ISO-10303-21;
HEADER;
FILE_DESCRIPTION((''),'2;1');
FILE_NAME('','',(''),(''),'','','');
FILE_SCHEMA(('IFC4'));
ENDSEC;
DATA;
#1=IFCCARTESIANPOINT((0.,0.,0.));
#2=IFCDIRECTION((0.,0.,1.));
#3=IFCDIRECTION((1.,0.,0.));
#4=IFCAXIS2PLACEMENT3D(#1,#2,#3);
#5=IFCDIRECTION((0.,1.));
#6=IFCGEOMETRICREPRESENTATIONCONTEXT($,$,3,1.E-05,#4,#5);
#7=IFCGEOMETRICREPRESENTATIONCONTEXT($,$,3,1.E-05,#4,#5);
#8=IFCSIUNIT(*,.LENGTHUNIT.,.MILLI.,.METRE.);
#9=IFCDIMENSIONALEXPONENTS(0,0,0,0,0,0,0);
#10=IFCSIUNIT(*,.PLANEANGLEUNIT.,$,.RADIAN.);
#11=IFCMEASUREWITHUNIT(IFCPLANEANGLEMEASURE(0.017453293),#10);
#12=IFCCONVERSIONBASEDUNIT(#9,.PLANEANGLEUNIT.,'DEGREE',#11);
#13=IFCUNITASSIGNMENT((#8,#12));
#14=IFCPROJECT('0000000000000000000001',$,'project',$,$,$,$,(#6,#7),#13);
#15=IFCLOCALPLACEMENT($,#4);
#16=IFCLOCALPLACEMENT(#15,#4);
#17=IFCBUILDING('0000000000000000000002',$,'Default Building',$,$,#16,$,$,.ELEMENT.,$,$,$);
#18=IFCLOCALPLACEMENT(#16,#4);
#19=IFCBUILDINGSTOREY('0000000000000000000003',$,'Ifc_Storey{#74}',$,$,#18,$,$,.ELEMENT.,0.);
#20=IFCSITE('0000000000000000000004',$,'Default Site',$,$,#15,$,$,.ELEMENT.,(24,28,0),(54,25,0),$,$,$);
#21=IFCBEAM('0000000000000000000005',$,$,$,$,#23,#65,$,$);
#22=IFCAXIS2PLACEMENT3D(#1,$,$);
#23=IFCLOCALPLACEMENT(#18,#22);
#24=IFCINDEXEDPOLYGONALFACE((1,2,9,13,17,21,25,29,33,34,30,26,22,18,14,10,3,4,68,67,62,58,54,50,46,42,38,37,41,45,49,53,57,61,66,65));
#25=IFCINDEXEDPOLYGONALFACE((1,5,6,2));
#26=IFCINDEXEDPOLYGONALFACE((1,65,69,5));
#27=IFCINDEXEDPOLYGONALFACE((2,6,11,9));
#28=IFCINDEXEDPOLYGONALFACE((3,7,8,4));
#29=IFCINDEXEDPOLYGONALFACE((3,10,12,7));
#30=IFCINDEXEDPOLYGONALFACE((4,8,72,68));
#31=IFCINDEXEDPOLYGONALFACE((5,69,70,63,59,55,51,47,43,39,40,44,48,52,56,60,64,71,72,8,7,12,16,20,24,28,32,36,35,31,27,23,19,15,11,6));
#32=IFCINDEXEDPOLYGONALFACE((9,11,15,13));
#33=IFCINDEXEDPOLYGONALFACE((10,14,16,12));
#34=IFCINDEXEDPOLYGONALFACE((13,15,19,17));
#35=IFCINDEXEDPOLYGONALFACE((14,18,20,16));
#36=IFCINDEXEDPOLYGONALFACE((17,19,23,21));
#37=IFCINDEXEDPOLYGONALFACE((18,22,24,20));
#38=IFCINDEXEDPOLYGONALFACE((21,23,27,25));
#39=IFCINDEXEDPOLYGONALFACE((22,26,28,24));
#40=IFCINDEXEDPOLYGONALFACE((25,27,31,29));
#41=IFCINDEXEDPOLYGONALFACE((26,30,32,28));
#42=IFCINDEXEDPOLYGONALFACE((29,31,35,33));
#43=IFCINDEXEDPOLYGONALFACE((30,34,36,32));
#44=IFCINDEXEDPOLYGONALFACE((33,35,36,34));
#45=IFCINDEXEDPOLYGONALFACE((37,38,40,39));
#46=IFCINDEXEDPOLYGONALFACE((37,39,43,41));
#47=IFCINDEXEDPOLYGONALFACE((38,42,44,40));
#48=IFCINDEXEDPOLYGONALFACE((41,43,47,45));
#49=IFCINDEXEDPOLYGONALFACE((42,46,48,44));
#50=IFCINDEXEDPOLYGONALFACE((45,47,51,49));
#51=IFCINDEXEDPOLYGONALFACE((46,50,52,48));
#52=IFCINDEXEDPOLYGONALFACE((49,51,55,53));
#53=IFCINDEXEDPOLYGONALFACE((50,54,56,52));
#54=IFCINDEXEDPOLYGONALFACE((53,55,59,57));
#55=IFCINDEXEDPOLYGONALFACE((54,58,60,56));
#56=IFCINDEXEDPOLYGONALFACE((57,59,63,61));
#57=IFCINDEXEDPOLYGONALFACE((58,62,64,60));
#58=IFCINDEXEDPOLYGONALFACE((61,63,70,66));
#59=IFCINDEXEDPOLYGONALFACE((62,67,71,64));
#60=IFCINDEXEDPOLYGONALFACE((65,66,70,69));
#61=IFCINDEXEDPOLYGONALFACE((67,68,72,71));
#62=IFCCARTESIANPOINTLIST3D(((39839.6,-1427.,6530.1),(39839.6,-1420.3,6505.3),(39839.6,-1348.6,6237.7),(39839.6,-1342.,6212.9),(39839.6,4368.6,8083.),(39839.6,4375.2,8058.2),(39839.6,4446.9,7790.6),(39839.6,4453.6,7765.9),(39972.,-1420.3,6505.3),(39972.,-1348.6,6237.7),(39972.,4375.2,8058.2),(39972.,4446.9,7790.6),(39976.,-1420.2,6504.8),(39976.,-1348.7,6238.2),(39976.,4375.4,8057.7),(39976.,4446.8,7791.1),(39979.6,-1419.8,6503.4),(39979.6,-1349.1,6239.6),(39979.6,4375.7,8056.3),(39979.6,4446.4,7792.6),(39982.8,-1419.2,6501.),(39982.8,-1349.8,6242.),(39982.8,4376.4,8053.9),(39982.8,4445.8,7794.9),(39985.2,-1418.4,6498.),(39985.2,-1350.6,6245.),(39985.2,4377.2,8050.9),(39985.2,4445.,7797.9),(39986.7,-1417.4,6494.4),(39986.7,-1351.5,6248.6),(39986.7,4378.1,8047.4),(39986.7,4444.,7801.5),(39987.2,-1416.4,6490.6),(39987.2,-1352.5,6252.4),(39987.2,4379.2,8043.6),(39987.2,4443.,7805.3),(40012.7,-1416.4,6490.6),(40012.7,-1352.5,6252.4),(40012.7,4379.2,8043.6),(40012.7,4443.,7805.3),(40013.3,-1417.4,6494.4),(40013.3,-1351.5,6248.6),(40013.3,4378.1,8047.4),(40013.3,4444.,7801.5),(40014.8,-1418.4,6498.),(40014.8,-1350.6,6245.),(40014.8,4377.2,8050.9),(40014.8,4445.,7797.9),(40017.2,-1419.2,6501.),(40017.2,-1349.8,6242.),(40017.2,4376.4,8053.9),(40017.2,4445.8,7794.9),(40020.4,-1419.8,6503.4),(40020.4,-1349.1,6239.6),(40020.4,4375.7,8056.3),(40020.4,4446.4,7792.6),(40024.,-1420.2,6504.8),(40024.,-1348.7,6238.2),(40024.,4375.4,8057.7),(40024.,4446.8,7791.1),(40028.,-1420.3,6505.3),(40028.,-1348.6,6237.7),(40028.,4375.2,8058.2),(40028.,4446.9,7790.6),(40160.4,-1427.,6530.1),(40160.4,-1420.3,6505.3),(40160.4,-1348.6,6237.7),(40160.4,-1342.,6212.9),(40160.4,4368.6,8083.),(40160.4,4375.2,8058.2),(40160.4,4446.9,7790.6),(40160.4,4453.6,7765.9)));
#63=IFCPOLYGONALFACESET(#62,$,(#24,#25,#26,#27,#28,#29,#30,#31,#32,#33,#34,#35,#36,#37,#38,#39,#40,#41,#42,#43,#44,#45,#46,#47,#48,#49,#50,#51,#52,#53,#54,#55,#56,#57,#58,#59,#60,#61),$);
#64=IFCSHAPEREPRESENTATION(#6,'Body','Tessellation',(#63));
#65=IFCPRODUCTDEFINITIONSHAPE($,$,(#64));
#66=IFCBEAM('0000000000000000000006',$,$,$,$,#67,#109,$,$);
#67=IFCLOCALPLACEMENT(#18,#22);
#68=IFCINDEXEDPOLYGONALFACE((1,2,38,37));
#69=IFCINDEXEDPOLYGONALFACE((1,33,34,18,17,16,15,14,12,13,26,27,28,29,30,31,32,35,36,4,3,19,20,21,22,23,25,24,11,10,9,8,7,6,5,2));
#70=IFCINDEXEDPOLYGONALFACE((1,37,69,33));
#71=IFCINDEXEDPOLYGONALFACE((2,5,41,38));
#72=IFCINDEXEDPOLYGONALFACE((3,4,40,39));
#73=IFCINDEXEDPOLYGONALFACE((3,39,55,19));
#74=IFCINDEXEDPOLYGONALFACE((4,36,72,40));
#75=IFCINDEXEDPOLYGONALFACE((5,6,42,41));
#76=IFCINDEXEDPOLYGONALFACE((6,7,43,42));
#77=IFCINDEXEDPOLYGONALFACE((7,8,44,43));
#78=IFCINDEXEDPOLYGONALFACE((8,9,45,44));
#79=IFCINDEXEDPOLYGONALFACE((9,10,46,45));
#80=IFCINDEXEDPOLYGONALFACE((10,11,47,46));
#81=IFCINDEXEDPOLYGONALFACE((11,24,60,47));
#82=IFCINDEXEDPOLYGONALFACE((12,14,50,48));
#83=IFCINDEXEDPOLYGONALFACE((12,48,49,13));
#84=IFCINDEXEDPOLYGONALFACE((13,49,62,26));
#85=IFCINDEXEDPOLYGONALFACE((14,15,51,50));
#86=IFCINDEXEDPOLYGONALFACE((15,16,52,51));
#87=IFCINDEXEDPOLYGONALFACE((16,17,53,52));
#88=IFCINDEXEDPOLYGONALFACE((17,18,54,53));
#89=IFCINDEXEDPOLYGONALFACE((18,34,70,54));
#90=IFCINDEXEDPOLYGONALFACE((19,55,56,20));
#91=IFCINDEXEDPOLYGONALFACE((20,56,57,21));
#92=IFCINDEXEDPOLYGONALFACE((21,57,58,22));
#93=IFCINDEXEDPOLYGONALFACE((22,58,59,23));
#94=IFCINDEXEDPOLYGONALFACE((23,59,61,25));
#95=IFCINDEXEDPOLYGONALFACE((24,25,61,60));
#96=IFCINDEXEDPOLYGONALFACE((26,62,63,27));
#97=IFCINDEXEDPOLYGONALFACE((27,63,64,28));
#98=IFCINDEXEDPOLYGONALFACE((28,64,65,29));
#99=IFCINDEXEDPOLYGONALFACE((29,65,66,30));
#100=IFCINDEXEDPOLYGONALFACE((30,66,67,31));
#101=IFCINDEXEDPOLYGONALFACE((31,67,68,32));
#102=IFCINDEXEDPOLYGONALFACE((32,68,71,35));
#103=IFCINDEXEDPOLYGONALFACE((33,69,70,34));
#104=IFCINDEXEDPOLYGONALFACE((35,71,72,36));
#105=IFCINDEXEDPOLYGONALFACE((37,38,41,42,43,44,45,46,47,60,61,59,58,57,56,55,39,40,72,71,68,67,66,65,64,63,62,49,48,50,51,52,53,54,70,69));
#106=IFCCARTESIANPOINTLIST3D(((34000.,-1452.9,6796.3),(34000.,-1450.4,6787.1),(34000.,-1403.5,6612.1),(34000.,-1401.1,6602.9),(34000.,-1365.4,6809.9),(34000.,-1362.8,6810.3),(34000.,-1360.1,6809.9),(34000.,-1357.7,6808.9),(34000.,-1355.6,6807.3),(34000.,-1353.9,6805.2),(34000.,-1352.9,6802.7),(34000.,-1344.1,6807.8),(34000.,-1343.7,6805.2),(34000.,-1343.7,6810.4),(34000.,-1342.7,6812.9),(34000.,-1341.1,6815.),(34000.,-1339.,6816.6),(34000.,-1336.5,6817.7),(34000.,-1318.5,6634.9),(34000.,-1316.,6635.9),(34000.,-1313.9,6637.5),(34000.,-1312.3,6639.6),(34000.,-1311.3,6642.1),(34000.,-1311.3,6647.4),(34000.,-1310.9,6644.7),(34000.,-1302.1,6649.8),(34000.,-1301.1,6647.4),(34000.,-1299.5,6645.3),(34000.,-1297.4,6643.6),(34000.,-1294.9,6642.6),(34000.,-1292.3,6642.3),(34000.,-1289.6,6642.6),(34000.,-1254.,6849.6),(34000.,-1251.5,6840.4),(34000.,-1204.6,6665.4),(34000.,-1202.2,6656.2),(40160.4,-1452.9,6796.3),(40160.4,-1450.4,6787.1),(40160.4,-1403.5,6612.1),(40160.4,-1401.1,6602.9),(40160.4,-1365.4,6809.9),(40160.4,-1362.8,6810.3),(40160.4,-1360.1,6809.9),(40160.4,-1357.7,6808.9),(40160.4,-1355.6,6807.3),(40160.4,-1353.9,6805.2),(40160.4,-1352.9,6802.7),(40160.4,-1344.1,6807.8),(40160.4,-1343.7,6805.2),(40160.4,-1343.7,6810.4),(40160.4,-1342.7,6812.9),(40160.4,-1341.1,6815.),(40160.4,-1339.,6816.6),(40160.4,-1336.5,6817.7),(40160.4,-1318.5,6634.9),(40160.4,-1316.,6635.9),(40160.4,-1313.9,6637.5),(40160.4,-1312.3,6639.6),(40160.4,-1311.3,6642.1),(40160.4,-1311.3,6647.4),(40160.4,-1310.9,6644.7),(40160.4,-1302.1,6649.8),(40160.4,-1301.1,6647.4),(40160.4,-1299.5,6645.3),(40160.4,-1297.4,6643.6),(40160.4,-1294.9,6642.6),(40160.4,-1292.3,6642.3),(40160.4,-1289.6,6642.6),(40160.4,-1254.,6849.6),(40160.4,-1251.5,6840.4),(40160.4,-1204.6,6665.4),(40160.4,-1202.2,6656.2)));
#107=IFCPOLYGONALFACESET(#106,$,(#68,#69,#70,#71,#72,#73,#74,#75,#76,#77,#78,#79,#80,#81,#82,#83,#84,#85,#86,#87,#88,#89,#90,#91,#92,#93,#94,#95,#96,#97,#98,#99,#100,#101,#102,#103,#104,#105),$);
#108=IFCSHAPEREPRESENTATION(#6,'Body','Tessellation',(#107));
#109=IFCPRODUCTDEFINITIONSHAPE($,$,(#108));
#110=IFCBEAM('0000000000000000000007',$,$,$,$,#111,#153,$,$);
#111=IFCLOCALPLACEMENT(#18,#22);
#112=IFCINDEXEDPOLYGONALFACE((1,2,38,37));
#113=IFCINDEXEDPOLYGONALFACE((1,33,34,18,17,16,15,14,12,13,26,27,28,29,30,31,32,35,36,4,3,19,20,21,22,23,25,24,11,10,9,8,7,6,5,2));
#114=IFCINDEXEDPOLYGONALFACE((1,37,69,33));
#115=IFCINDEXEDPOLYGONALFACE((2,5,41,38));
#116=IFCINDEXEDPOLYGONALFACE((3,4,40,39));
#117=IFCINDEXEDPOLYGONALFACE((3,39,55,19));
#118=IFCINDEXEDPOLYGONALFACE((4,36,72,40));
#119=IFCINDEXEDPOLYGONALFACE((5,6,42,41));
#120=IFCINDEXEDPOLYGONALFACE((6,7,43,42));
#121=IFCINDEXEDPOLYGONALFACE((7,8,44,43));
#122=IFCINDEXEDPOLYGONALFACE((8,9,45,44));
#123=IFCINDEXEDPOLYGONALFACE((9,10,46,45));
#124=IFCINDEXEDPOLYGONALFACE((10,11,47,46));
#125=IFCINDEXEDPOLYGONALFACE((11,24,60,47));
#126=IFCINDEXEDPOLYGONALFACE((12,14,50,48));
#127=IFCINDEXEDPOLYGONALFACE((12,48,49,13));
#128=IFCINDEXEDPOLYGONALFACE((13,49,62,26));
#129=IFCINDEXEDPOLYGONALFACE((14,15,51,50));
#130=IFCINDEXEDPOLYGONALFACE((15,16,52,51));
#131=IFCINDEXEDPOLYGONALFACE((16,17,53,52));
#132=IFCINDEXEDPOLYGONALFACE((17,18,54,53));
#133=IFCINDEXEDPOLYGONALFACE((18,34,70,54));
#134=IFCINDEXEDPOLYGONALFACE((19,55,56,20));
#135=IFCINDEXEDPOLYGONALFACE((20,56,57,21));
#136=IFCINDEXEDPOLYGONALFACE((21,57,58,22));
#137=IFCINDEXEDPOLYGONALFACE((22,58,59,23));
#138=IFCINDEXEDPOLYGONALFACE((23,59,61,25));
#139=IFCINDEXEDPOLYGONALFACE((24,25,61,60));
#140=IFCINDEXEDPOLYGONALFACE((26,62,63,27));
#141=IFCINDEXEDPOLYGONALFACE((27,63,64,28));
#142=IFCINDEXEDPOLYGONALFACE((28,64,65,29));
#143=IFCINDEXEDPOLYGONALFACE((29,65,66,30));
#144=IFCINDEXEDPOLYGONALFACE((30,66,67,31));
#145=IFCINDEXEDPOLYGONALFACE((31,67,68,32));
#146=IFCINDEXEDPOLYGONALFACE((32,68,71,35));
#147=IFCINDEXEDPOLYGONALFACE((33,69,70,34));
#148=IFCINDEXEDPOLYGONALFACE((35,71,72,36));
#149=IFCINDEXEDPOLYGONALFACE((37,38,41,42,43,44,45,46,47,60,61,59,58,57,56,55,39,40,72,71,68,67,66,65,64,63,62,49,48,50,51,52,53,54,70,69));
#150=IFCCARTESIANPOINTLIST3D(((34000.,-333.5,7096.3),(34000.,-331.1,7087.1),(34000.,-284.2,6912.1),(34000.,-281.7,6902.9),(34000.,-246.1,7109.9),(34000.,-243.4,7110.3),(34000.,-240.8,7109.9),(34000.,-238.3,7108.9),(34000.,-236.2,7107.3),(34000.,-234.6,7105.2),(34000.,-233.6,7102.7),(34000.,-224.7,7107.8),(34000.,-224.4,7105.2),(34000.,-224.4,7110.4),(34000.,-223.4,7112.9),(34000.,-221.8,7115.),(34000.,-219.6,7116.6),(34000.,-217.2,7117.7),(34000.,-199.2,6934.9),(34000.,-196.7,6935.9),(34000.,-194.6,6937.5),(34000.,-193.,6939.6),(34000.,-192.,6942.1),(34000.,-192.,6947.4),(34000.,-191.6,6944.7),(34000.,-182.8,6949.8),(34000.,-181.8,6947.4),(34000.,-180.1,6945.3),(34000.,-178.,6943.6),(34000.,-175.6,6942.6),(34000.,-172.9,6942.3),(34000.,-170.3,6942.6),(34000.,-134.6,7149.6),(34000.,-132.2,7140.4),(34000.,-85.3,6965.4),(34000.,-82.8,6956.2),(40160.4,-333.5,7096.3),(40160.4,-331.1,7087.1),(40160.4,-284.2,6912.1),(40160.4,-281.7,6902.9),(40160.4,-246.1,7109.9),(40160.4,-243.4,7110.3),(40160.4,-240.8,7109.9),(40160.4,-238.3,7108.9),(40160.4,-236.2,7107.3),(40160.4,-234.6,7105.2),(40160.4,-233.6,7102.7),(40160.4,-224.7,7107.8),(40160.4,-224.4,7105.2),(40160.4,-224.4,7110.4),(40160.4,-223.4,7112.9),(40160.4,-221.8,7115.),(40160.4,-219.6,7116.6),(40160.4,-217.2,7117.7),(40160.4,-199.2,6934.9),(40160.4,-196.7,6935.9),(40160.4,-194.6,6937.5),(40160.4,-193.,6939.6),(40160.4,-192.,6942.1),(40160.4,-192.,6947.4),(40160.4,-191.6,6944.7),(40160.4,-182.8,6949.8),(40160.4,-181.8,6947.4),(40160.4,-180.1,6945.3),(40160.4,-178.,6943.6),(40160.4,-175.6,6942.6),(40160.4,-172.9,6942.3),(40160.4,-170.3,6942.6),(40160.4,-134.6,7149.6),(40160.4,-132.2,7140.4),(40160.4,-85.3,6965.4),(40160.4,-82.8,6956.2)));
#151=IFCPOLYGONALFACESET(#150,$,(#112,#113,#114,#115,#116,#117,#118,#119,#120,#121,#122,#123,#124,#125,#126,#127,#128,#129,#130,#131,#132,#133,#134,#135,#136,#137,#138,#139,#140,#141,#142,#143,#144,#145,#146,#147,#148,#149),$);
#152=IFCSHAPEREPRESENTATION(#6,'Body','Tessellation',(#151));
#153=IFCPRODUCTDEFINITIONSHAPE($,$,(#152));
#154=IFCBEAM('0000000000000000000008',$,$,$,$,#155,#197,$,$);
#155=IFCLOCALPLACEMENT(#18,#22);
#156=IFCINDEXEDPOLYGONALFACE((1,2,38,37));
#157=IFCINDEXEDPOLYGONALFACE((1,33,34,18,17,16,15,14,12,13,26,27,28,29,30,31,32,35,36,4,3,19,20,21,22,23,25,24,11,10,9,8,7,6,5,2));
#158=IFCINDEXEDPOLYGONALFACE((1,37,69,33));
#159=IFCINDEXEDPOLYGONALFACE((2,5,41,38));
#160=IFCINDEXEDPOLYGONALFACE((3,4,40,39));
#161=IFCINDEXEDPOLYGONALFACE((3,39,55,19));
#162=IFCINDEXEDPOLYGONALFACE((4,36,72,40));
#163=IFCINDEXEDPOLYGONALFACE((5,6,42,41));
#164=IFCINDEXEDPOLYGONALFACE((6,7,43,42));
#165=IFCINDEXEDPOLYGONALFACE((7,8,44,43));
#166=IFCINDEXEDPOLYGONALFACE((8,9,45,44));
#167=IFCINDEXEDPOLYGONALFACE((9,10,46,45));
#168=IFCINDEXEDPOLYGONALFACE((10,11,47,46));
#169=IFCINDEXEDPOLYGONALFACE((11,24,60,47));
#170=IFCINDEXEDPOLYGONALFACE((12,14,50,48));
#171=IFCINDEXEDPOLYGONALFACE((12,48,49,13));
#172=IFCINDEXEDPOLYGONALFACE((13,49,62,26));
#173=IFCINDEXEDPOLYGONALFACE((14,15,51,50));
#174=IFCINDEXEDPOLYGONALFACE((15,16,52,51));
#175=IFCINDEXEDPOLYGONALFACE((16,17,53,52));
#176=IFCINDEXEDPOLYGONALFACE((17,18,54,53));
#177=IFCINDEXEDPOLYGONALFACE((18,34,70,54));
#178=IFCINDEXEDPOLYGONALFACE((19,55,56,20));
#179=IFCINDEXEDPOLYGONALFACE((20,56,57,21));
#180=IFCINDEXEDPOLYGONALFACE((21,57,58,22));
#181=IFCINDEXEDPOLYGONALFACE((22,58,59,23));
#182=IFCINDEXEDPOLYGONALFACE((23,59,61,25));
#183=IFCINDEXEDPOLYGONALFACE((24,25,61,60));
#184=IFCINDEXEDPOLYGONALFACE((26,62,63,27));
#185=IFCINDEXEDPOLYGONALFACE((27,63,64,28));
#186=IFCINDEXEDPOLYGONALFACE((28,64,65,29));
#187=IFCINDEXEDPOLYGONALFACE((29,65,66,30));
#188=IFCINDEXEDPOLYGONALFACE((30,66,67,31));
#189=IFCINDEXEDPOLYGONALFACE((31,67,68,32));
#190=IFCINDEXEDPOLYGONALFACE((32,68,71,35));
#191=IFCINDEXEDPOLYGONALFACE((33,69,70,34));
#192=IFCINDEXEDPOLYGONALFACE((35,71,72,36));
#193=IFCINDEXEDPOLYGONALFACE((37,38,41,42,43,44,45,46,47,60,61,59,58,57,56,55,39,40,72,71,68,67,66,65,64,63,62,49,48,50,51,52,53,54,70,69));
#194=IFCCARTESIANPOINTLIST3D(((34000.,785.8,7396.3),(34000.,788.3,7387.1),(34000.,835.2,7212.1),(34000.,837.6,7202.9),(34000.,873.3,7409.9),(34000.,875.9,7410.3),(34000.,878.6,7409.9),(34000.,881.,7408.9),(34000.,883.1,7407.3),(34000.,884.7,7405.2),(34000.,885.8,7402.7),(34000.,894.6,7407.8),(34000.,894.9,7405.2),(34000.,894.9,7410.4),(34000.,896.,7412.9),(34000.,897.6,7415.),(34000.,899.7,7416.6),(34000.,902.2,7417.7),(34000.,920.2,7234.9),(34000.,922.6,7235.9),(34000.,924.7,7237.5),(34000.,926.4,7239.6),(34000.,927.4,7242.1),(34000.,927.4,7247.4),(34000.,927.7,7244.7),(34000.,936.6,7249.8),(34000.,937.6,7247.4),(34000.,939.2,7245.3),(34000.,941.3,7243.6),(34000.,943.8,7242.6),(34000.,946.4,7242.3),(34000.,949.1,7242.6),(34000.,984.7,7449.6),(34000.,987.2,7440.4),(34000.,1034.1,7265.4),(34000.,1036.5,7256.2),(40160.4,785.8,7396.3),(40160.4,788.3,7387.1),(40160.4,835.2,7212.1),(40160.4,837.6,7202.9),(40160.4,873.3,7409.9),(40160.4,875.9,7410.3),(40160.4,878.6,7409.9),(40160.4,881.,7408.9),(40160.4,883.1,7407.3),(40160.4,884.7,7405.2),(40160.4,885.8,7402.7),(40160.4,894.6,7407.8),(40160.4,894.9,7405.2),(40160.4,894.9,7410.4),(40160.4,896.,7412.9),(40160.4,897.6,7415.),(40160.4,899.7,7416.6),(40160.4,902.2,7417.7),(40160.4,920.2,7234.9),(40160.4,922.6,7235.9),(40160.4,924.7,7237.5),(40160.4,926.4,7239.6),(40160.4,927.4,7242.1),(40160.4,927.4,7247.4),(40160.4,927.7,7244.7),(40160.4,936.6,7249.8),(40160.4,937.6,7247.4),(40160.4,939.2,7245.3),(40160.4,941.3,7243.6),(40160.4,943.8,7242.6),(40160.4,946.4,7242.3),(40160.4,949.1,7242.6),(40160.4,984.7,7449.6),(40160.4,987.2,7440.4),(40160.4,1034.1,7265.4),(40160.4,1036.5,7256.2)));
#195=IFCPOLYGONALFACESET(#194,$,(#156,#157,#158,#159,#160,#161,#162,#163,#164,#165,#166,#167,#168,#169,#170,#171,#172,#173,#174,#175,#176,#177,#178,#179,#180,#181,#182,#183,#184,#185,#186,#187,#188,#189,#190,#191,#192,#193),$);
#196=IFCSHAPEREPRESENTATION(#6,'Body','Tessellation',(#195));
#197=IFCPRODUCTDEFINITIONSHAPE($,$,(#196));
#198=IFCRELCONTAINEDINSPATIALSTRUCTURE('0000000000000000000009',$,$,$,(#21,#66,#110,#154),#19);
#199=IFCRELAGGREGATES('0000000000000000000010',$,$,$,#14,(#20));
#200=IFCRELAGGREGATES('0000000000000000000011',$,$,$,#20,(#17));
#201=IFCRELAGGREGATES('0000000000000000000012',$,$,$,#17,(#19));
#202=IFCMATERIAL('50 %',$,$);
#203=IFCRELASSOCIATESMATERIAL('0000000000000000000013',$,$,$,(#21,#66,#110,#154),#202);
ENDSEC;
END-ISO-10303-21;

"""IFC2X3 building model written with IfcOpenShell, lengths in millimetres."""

from ifc_helpers import new_model, entity, si_unit, converted_unit, direction, frame, origin_with_axes, origin_2d_with_axis, place, context, project, spatial, i_section, extrude, material, element, save


model = new_model("IFC2X3")

# Units and contexts
context_of_model_1 = context(None, 3, precision=1e-05, world=origin_with_axes(), true_north=direction((0.0, 1.0)))
context_of_model_2 = context(None, 3, precision=1e-05, world=origin_with_axes(), true_north=direction((0.0, 1.0)))
ifc_project = project(units=[si_unit("LENGTHUNIT", "METRE", prefix="MILLI"), converted_unit("PLANEANGLEUNIT", "DEGREE", entity("IfcPlaneAngleMeasure", 0.017453293), si_unit("PLANEANGLEUNIT", "RADIAN"), dimensions=[0, 0, 0, 0, 0, 0, 0])], contexts=[context_of_model_1, context_of_model_2])

# Site, building, storey
site_placement = place(None, origin_with_axes())
site = spatial("IfcSite", under=ifc_project, at=site_placement, Name="Default Site", CompositionType="ELEMENT", RefLatitude=(24, 28, 0), RefLongitude=(54, 25, 0))
building_placement = place(site_placement, origin_with_axes())
building = spatial("IfcBuilding", under=site, at=building_placement, Name="Default Building", CompositionType="ELEMENT")
storey_placement = place(building_placement, origin_with_axes())
storey = spatial("IfcBuildingStorey", under=building, at=storey_placement, Name="Ifc_Storey{#74}", CompositionType="ELEMENT", Elevation=0.0)

# Shared definitions
ifc_material_1 = material(Name="50 %")

# Beams
for number, where, z_axis, x_axis in (
    (1, (40000.0, -1384.5, 6371.5), (0.0, 0.0, 1.0), (0.0, -1.0, 0.0)),
):
    element("IfcBeam", number, at=place(storey_placement, frame(where, z_axis=z_axis, x_axis=x_axis)), inside=storey, material=ifc_material_1, context=context_of_model_1, shape_type="SweptSolid", body=[
        extrude(i_section(OverallWidth=320.9, OverallDepth=328.3, WebThickness=25.5, FlangeThickness=25.6, FilletRadius=15.2, at=origin_2d_with_axis()), frame((0.0, 0.0, 0.0), z_axis=(-0.965926, 0.0, 0.258819), x_axis=(0.0, 1.0, 0.0)), (0.0, 0.0, 1.0), 6000.0),
    ])
for number, where, z_axis, x_axis in (
    (2, (34000.0, -1327.5, 6726.3), (0.0, -0.258819, 0.965926), (-1.0, 0.0, 0.0)),
    (3, (34000.0, -208.2, 7026.3), (0.0, -0.258819, 0.965926), (-1.0, 0.0, 0.0)),
    (4, (34000.0, 911.2, 7326.3), (0.0, -0.258819, 0.965926), (-1.0, 0.0, 0.0)),
):
    element("IfcBeam", number, at=place(storey_placement, frame(where, z_axis=z_axis, x_axis=x_axis)), inside=storey, material=ifc_material_1, context=context_of_model_1, shape_type="SweptSolid", body=[
        extrude(i_section(OverallWidth=205.9, OverallDepth=200.2, WebThickness=9.5, FlangeThickness=9.5, FilletRadius=10.2, at=origin_2d_with_axis()), frame((0.0, 0.0, 0.0), z_axis=(-1.0, 0.0, 0.0), x_axis=(0.0, 1.0, 0.0)), (0.0, 0.0, 1.0), 6160.4),
    ])

save(model, "model.ifc")
